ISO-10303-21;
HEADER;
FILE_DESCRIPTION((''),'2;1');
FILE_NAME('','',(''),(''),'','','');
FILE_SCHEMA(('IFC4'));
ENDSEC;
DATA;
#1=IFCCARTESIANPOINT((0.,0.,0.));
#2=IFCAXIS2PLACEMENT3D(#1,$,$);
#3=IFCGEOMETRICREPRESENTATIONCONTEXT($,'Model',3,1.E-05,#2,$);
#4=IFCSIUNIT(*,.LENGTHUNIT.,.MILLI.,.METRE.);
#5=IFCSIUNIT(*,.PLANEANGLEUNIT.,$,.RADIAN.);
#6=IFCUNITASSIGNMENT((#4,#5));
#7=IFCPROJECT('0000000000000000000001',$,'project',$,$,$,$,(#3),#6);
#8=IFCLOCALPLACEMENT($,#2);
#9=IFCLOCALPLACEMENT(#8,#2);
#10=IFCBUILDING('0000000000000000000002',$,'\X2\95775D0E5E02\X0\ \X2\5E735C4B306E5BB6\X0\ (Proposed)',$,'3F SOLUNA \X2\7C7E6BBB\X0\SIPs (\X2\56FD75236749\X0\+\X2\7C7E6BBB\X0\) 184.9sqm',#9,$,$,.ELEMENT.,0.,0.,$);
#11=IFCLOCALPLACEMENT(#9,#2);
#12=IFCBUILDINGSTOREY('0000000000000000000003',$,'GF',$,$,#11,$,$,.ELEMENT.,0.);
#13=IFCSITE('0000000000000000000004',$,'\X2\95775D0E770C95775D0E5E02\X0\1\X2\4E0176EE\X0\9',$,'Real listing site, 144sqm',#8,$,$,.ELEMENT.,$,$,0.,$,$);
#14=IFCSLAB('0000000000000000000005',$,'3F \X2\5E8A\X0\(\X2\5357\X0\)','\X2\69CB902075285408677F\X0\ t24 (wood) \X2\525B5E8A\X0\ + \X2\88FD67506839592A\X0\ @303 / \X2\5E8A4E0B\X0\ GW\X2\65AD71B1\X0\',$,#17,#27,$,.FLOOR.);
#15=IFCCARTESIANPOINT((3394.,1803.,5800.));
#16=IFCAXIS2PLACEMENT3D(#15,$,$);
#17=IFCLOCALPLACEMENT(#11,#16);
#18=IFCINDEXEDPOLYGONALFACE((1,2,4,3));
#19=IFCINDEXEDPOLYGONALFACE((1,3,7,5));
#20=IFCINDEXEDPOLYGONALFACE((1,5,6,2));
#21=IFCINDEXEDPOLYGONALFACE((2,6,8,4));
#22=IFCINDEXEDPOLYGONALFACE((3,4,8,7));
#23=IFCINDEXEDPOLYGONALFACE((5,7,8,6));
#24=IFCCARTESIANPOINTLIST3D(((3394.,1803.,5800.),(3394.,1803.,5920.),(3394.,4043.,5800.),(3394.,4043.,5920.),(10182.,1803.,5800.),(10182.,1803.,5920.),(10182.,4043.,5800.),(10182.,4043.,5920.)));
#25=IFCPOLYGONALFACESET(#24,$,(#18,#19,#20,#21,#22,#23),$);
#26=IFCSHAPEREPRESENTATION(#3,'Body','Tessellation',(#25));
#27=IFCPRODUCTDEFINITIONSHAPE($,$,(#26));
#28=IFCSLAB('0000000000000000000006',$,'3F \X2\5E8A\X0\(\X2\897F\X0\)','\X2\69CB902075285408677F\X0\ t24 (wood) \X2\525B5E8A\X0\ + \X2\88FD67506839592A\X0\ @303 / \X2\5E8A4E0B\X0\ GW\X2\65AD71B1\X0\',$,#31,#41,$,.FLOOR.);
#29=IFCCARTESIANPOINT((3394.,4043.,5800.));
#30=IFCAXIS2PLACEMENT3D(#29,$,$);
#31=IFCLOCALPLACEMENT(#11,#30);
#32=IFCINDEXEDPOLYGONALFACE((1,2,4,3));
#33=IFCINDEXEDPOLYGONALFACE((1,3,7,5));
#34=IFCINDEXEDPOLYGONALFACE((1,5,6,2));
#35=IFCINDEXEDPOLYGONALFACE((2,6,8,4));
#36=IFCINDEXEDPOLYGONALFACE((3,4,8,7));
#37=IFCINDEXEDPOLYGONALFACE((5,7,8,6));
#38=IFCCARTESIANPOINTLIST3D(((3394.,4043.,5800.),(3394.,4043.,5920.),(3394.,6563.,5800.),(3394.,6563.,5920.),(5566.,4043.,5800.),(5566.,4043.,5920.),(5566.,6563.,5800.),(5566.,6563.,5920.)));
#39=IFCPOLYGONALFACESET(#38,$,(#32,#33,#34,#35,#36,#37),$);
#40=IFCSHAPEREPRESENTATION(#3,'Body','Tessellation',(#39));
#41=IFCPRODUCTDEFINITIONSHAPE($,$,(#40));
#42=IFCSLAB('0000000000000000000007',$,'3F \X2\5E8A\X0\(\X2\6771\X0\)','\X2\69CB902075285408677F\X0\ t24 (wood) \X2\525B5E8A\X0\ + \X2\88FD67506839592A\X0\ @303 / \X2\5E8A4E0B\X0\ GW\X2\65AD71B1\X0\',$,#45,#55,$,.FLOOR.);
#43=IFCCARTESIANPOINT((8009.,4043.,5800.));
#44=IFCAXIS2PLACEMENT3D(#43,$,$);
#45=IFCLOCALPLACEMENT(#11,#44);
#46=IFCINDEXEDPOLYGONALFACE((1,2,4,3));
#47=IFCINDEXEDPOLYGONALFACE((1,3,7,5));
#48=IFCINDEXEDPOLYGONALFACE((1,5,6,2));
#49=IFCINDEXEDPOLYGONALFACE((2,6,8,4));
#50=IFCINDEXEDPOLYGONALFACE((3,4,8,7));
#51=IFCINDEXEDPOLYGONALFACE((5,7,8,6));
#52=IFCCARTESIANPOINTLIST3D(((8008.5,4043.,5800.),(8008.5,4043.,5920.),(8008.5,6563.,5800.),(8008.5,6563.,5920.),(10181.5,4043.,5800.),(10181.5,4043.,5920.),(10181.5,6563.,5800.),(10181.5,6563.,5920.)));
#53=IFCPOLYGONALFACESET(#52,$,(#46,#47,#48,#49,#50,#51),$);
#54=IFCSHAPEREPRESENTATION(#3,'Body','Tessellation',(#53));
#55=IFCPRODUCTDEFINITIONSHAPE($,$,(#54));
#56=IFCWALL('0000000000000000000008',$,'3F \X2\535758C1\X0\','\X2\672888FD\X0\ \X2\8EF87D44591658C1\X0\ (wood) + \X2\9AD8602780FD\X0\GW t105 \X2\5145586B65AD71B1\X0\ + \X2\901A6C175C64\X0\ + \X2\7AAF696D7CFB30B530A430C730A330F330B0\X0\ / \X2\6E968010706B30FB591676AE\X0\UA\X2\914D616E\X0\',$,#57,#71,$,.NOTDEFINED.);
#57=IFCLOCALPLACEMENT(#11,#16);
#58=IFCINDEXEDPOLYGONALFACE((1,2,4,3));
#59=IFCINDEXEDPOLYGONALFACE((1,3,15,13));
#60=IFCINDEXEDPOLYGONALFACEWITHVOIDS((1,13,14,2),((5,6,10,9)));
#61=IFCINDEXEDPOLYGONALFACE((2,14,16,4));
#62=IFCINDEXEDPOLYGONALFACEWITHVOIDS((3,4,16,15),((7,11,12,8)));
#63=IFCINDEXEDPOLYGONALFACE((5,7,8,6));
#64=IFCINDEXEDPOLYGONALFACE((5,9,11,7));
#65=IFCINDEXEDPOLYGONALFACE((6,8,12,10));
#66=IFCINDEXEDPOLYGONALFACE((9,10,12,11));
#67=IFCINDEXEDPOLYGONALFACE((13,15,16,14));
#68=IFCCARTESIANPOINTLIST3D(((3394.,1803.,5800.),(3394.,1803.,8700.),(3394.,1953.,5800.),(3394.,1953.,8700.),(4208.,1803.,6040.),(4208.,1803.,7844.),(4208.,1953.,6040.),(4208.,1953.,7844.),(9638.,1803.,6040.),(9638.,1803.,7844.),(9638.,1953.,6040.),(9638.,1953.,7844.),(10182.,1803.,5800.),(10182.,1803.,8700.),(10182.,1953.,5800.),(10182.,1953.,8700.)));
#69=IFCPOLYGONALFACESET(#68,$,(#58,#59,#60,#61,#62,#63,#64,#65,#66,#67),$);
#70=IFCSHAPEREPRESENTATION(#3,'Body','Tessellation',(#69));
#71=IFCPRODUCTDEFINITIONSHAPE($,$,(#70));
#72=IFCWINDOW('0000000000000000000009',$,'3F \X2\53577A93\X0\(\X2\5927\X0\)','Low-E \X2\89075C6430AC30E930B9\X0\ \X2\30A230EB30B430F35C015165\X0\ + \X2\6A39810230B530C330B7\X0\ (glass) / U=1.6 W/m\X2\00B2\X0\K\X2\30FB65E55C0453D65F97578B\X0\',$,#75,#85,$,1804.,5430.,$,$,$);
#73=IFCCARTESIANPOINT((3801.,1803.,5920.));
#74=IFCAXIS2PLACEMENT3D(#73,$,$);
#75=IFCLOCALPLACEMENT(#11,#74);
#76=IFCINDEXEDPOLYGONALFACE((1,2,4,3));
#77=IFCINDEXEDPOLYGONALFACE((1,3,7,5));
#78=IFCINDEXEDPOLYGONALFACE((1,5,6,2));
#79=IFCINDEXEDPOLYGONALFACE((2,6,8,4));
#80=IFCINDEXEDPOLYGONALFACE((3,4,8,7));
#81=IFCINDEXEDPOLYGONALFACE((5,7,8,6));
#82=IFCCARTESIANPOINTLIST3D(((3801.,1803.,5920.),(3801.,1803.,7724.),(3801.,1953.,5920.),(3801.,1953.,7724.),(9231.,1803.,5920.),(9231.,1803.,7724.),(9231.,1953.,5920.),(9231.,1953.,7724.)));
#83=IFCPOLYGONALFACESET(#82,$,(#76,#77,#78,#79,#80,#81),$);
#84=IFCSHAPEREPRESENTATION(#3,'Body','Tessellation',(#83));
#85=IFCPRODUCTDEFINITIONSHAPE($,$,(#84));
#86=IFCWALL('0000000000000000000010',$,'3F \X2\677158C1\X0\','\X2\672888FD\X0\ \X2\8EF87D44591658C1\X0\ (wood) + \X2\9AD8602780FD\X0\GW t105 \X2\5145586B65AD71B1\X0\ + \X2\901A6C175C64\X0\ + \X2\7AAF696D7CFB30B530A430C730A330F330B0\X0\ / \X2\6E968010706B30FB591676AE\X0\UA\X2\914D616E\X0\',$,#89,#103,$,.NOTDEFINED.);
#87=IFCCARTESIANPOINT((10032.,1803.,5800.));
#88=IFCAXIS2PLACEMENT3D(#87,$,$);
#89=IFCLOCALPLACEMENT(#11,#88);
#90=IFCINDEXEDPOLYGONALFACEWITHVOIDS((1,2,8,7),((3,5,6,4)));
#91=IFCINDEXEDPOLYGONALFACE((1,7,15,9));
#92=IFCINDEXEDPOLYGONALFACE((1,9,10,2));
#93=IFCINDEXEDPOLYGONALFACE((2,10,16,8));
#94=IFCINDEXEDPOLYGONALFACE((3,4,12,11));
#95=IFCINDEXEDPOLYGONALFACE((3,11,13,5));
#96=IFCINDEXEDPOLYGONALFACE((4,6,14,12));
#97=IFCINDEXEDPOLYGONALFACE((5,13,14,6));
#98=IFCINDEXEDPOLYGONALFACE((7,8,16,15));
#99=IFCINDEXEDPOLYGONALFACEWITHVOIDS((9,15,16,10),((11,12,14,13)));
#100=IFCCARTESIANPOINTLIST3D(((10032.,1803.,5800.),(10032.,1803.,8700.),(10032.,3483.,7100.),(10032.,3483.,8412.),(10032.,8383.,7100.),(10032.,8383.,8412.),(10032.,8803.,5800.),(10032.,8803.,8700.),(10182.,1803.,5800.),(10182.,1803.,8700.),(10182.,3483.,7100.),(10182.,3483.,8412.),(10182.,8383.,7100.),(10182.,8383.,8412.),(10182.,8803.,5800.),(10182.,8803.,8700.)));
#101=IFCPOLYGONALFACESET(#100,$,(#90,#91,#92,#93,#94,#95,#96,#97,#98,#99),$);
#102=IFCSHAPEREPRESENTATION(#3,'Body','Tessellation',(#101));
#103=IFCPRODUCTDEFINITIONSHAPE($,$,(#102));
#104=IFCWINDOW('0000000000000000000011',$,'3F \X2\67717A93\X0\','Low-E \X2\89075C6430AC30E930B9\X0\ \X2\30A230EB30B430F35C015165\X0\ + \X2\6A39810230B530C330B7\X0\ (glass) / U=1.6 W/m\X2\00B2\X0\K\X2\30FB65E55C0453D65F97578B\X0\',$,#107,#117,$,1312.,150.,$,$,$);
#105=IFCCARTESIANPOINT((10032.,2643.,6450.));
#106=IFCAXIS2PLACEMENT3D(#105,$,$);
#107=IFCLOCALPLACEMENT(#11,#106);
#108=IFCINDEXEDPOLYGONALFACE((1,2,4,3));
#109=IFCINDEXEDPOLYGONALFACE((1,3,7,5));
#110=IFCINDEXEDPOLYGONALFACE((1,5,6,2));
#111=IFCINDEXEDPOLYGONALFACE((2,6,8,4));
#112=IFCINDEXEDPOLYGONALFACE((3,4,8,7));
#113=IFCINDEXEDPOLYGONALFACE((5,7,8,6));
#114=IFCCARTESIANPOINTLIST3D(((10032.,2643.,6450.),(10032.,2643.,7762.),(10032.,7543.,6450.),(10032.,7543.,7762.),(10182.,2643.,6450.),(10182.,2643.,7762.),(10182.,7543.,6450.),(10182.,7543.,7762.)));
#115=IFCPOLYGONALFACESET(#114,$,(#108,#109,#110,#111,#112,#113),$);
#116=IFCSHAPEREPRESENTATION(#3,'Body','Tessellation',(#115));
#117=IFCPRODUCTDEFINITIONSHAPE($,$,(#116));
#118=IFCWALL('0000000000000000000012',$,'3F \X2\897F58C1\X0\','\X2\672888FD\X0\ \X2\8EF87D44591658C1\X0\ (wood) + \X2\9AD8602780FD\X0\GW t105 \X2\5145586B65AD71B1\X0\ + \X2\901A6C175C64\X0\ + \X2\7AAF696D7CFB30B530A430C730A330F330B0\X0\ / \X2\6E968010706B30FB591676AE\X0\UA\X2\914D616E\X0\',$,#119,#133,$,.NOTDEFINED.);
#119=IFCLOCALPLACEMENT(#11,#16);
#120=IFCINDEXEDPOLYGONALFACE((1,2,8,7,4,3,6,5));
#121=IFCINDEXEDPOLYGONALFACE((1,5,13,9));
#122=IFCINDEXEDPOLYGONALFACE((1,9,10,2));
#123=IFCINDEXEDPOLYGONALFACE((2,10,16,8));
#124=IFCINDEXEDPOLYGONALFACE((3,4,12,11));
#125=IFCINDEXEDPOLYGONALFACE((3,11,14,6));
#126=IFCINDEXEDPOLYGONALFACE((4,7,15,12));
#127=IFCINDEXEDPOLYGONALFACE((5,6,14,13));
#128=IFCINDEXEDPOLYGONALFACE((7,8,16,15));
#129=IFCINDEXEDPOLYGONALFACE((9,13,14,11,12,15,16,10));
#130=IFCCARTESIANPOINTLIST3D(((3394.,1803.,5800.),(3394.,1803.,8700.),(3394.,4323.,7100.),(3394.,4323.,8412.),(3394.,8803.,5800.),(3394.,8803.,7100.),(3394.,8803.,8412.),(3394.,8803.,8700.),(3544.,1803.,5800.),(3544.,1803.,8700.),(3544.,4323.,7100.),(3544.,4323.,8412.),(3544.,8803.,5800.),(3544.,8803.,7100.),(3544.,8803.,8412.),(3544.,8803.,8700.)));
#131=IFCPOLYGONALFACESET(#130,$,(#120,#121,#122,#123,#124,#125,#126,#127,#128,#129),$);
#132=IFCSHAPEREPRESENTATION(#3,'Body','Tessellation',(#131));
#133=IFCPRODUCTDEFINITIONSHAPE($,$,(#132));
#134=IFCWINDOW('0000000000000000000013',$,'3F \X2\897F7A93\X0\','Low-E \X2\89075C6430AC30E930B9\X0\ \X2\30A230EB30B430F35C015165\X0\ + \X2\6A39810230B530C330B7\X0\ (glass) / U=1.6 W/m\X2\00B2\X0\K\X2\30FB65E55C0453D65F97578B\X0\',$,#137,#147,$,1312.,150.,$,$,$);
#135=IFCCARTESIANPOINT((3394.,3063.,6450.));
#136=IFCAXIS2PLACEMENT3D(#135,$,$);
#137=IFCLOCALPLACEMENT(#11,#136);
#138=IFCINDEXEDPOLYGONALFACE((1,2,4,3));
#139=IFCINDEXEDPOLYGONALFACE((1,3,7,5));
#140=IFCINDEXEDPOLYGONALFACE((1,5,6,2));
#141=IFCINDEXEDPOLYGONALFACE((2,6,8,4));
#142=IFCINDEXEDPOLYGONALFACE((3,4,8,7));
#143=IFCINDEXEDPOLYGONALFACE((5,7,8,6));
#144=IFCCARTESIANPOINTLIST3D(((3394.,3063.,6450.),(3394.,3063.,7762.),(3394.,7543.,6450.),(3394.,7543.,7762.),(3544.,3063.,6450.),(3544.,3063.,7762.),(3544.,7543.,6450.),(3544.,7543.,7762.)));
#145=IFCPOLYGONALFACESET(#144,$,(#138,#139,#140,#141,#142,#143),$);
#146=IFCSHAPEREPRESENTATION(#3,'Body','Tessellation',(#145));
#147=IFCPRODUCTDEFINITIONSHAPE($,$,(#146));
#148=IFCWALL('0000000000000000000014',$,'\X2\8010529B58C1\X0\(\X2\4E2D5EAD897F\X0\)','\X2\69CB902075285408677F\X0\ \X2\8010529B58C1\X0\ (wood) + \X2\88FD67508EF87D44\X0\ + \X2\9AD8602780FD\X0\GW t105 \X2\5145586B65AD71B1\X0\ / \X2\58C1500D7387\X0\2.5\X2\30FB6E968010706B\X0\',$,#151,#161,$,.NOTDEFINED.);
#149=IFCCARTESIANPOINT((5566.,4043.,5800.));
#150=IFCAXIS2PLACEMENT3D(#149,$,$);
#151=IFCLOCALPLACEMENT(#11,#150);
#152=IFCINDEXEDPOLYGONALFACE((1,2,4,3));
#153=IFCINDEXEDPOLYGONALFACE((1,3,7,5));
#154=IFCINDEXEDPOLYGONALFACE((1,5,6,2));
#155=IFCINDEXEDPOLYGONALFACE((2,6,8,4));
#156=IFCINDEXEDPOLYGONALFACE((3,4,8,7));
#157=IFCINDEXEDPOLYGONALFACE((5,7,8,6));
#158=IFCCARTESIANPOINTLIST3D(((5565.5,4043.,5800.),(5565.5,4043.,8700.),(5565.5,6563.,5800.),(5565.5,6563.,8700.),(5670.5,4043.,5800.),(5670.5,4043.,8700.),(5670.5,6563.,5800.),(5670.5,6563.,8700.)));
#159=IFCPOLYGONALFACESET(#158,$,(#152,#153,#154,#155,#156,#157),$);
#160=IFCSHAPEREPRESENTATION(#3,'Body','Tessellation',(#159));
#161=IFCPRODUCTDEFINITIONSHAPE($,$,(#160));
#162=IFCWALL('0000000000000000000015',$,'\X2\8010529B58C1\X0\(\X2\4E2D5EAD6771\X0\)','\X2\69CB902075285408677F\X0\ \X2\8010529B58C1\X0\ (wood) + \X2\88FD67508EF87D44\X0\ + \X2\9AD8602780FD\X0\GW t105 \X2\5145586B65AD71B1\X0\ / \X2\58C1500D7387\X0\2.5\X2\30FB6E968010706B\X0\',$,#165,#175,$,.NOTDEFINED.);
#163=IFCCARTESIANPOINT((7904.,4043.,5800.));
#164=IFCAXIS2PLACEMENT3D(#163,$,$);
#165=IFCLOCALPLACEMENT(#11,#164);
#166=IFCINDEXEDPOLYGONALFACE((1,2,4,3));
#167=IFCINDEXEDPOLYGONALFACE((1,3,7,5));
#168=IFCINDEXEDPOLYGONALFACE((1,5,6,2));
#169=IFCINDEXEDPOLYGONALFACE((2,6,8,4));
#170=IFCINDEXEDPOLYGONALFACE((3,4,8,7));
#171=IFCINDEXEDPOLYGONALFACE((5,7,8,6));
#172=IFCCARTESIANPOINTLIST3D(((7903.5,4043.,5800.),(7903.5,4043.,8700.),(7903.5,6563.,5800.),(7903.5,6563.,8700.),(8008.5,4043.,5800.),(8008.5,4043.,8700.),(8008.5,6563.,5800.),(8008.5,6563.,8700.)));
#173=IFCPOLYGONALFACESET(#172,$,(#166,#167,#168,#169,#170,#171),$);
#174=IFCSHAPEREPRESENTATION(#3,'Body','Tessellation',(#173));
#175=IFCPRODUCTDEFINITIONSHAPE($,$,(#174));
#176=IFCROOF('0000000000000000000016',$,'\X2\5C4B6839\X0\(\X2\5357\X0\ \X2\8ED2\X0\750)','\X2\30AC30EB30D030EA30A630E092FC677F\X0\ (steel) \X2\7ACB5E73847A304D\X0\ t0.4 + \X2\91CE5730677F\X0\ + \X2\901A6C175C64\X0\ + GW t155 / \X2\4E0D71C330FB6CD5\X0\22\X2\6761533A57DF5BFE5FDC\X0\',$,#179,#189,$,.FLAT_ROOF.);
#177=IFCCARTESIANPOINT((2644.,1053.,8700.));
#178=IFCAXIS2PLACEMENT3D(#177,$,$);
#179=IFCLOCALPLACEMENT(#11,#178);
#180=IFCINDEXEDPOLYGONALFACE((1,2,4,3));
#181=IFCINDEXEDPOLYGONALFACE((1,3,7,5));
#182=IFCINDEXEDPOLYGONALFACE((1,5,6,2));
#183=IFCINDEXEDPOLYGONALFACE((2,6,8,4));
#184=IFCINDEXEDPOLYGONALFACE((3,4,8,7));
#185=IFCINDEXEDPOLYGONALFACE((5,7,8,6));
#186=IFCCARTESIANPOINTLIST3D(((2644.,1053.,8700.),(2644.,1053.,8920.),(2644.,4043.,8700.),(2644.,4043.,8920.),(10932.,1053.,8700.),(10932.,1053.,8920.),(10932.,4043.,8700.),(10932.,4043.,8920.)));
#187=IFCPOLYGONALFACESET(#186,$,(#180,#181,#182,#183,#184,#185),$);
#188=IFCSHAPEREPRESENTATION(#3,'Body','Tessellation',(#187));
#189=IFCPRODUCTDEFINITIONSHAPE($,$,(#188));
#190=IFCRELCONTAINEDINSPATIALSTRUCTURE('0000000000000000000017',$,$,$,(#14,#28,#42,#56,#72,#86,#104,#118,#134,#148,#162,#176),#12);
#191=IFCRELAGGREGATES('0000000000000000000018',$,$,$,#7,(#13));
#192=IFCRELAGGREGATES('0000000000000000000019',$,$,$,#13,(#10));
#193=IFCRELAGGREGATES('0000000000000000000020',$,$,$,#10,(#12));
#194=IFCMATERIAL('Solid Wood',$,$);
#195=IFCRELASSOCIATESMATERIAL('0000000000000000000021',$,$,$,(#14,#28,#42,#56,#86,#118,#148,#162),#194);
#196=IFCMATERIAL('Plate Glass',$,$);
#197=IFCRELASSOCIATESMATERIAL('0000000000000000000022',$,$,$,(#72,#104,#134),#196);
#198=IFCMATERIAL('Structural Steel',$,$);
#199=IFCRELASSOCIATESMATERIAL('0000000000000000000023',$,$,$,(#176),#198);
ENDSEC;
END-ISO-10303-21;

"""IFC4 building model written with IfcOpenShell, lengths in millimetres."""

from ifc_helpers import new_model, si_unit, frame, frame_2d, origin, place, context, project, spatial, rectangle, extrude, material, element, fill, save


model = new_model("IFC4")

# Units and contexts
model_context = context("Model", 3, precision=1e-05, world=origin())
ifc_project = project(units=[si_unit("LENGTHUNIT", "METRE", prefix="MILLI"), si_unit("PLANEANGLEUNIT", "RADIAN")], contexts=[model_context])

# Site, building, storey
site_placement = place(None, origin())
site = spatial("IfcSite", under=ifc_project, at=site_placement, Name="長崎県長崎市1丁目9", ObjectType="Real listing site, 144sqm", CompositionType="ELEMENT", RefElevation=0.0)
building_placement = place(site_placement, origin())
building = spatial("IfcBuilding", under=site, at=building_placement, Name="長崎市 平屋の家 (Proposed)", ObjectType="3F SOLUNA 籾殻SIPs (国産杉+籾殻) 184.9sqm", CompositionType="ELEMENT", ElevationOfRefHeight=0.0, ElevationOfTerrain=0.0)
storey_placement = place(building_placement, origin())
storey = spatial("IfcBuildingStorey", under=building, at=storey_placement, Name="GF", CompositionType="ELEMENT", Elevation=0.0)

# Slabs
ifc_material_1 = material(Name="Solid Wood")
slab_1_placement = place(storey_placement, frame((3394.0, 1803.0, 5800.0)))
element("IfcSlab", 1, at=slab_1_placement, inside=storey, material=ifc_material_1, Name="3F 床(南)", Description="構造用合板 t24 (wood) 剛床 + 製材根太 @303 / 床下 GW断熱", PredefinedType="FLOOR", context=model_context, shape_type="SweptSolid", body=[
    extrude(rectangle(XDim=6788.0, YDim=2240.0, at=frame_2d((3394.0, 1120.0))), frame((3394.0, 1803.0, 5800.0)), (0.0, 0.0, 1.0), 120.0),
])
slab_2_placement = place(storey_placement, frame((3394.0, 4043.0, 5800.0)))
element("IfcSlab", 2, at=slab_2_placement, inside=storey, material=ifc_material_1, Name="3F 床(西)", Description="構造用合板 t24 (wood) 剛床 + 製材根太 @303 / 床下 GW断熱", PredefinedType="FLOOR", context=model_context, shape_type="SweptSolid", body=[
    extrude(rectangle(XDim=2172.0, YDim=2520.0, at=frame_2d((1086.0, 1260.0))), frame((3394.0, 4043.0, 5800.0)), (0.0, 0.0, 1.0), 120.0),
])
slab_3_placement = place(storey_placement, frame((8009.0, 4043.0, 5800.0)))
element("IfcSlab", 3, at=slab_3_placement, inside=storey, material=ifc_material_1, Name="3F 床(東)", Description="構造用合板 t24 (wood) 剛床 + 製材根太 @303 / 床下 GW断熱", PredefinedType="FLOOR", context=model_context, shape_type="SweptSolid", body=[
    extrude(rectangle(XDim=2173.0, YDim=2520.0, at=frame_2d((1086.0, 1260.0))), frame((8009.0, 4043.0, 5800.0)), (0.0, 0.0, 1.0), 120.0),
])

# Walls, openings, windows
wall_1_placement = place(storey_placement, frame((3394.0, 1803.0, 5800.0)))
wall_1 = element("IfcWall", 4, at=wall_1_placement, inside=storey, material=ifc_material_1, Name="3F 南壁", Description="木製 軸組外壁 (wood) + 高性能GW t105 充填断熱 + 通気層 + 窯業系サイディング / 準耐火・外皮UA配慮", PredefinedType="NOTDEFINED", context=model_context, shape_type="SweptSolid", body=[
    extrude(rectangle(XDim=6788.0, YDim=150.0, at=frame_2d((3394.0, 75.0))), frame((3394.0, 1803.0, 5800.0)), (0.0, 0.0, 1.0), 2900.0),
])
opening_1_placement = place(storey_placement, frame((3801.0, 1803.0, 5920.0)))
opening_1 = element("IfcOpeningElement", 5, at=opening_1_placement, cuts=wall_1, PredefinedType="NOTDEFINED", context=model_context, shape_type="SweptSolid", body=[
    extrude(rectangle(XDim=5430.0, YDim=150.0, at=frame_2d((2715.0, 75.0))), frame((3801.0, 1803.0, 5920.0)), (0.0, 0.0, 1.0), 1804.0),
])
ifc_material_2 = material(Name="Plate Glass")
window_1_placement = place(storey_placement, frame((3801.0, 1803.0, 5920.0)))
window_1 = element("IfcWindow", 6, at=window_1_placement, inside=storey, material=ifc_material_2, Name="3F 南窓(大)", Description="Low-E 複層ガラス アルゴン封入 + 樹脂サッシ (glass) / U=1.6 W/m²K・日射取得型", OverallHeight=1804.0, OverallWidth=5430.0, context=model_context, shape_type="SweptSolid", body=[
    extrude(rectangle(XDim=5430.0, YDim=150.0, at=frame_2d((2715.0, 75.0))), frame((3801.0, 1803.0, 5920.0)), (0.0, 0.0, 1.0), 1804.0),
])
fill(opening_1, window_1)
wall_2_placement = place(storey_placement, frame((10032.0, 1803.0, 5800.0)))
wall_2 = element("IfcWall", 7, at=wall_2_placement, inside=storey, material=ifc_material_1, Name="3F 東壁", Description="木製 軸組外壁 (wood) + 高性能GW t105 充填断熱 + 通気層 + 窯業系サイディング / 準耐火・外皮UA配慮", PredefinedType="NOTDEFINED", context=model_context, shape_type="SweptSolid", body=[
    extrude(rectangle(XDim=150.0, YDim=7000.0, at=frame_2d((75.0, 3500.0))), frame((10032.0, 1803.0, 5800.0)), (0.0, 0.0, 1.0), 2900.0),
])
opening_2_placement = place(storey_placement, frame((10032.0, 2643.0, 6450.0)))
opening_2 = element("IfcOpeningElement", 8, at=opening_2_placement, cuts=wall_2, PredefinedType="NOTDEFINED", context=model_context, shape_type="SweptSolid", body=[
    extrude(rectangle(XDim=150.0, YDim=4900.0, at=frame_2d((75.0, 2450.0))), frame((10032.0, 2643.0, 6450.0)), (0.0, 0.0, 1.0), 1312.0),
])
window_2_placement = place(storey_placement, frame((10032.0, 2643.0, 6450.0)))
window_2 = element("IfcWindow", 9, at=window_2_placement, inside=storey, material=ifc_material_2, Name="3F 東窓", Description="Low-E 複層ガラス アルゴン封入 + 樹脂サッシ (glass) / U=1.6 W/m²K・日射取得型", OverallHeight=1312.0, OverallWidth=150.0, context=model_context, shape_type="SweptSolid", body=[
    extrude(rectangle(XDim=150.0, YDim=4900.0, at=frame_2d((75.0, 2450.0))), frame((10032.0, 2643.0, 6450.0)), (0.0, 0.0, 1.0), 1312.0),
])
fill(opening_2, window_2)
wall_3_placement = place(storey_placement, frame((3394.0, 1803.0, 5800.0)))
wall_3 = element("IfcWall", 10, at=wall_3_placement, inside=storey, material=ifc_material_1, Name="3F 西壁", Description="木製 軸組外壁 (wood) + 高性能GW t105 充填断熱 + 通気層 + 窯業系サイディング / 準耐火・外皮UA配慮", PredefinedType="NOTDEFINED", context=model_context, shape_type="SweptSolid", body=[
    extrude(rectangle(XDim=150.0, YDim=7000.0, at=frame_2d((75.0, 3500.0))), frame((3394.0, 1803.0, 5800.0)), (0.0, 0.0, 1.0), 2900.0),
])
opening_3_placement = place(storey_placement, frame((3394.0, 3063.0, 6450.0)))
opening_3 = element("IfcOpeningElement", 11, at=opening_3_placement, cuts=wall_3, PredefinedType="NOTDEFINED", context=model_context, shape_type="SweptSolid", body=[
    extrude(rectangle(XDim=150.0, YDim=4480.0, at=frame_2d((75.0, 2240.0))), frame((3394.0, 3063.0, 6450.0)), (0.0, 0.0, 1.0), 1312.0),
])
window_3_placement = place(storey_placement, frame((3394.0, 3063.0, 6450.0)))
window_3 = element("IfcWindow", 12, at=window_3_placement, inside=storey, material=ifc_material_2, Name="3F 西窓", Description="Low-E 複層ガラス アルゴン封入 + 樹脂サッシ (glass) / U=1.6 W/m²K・日射取得型", OverallHeight=1312.0, OverallWidth=150.0, context=model_context, shape_type="SweptSolid", body=[
    extrude(rectangle(XDim=150.0, YDim=4480.0, at=frame_2d((75.0, 2240.0))), frame((3394.0, 3063.0, 6450.0)), (0.0, 0.0, 1.0), 1312.0),
])
fill(opening_3, window_3)

# Walls
wall_4_placement = place(storey_placement, frame((5566.0, 4043.0, 5800.0)))
element("IfcWall", 13, at=wall_4_placement, inside=storey, material=ifc_material_1, Name="耐力壁(中庭西)", Description="構造用合板 耐力壁 (wood) + 製材軸組 + 高性能GW t105 充填断熱 / 壁倍率2.5・準耐火", PredefinedType="NOTDEFINED", context=model_context, shape_type="SweptSolid", body=[
    extrude(rectangle(XDim=105.0, YDim=2520.0, at=frame_2d((52.0, 1260.0))), frame((5566.0, 4043.0, 5800.0)), (0.0, 0.0, 1.0), 2900.0),
])
wall_5_placement = place(storey_placement, frame((7904.0, 4043.0, 5800.0)))
element("IfcWall", 14, at=wall_5_placement, inside=storey, material=ifc_material_1, Name="耐力壁(中庭東)", Description="構造用合板 耐力壁 (wood) + 製材軸組 + 高性能GW t105 充填断熱 / 壁倍率2.5・準耐火", PredefinedType="NOTDEFINED", context=model_context, shape_type="SweptSolid", body=[
    extrude(rectangle(XDim=105.0, YDim=2520.0, at=frame_2d((52.0, 1260.0))), frame((7904.0, 4043.0, 5800.0)), (0.0, 0.0, 1.0), 2900.0),
])

# Roof
ifc_material_3 = material(Name="Structural Steel")
roof_1_placement = place(storey_placement, frame((2644.0, 1053.0, 8700.0)))
element("IfcRoof", 15, at=roof_1_placement, inside=storey, material=ifc_material_3, Name="屋根(南 軒750)", Description="ガルバリウム鋼板 (steel) 立平葺き t0.4 + 野地板 + 通気層 + GW t155 / 不燃・法22条区域対応", PredefinedType="FLAT_ROOF", context=model_context, shape_type="SweptSolid", body=[
    extrude(rectangle(XDim=8288.0, YDim=2990.0, at=frame_2d((4144.0, 1495.0))), frame((2644.0, 1053.0, 8700.0)), (0.0, 0.0, 1.0), 220.0),
])

save(model, "model.ifc")
